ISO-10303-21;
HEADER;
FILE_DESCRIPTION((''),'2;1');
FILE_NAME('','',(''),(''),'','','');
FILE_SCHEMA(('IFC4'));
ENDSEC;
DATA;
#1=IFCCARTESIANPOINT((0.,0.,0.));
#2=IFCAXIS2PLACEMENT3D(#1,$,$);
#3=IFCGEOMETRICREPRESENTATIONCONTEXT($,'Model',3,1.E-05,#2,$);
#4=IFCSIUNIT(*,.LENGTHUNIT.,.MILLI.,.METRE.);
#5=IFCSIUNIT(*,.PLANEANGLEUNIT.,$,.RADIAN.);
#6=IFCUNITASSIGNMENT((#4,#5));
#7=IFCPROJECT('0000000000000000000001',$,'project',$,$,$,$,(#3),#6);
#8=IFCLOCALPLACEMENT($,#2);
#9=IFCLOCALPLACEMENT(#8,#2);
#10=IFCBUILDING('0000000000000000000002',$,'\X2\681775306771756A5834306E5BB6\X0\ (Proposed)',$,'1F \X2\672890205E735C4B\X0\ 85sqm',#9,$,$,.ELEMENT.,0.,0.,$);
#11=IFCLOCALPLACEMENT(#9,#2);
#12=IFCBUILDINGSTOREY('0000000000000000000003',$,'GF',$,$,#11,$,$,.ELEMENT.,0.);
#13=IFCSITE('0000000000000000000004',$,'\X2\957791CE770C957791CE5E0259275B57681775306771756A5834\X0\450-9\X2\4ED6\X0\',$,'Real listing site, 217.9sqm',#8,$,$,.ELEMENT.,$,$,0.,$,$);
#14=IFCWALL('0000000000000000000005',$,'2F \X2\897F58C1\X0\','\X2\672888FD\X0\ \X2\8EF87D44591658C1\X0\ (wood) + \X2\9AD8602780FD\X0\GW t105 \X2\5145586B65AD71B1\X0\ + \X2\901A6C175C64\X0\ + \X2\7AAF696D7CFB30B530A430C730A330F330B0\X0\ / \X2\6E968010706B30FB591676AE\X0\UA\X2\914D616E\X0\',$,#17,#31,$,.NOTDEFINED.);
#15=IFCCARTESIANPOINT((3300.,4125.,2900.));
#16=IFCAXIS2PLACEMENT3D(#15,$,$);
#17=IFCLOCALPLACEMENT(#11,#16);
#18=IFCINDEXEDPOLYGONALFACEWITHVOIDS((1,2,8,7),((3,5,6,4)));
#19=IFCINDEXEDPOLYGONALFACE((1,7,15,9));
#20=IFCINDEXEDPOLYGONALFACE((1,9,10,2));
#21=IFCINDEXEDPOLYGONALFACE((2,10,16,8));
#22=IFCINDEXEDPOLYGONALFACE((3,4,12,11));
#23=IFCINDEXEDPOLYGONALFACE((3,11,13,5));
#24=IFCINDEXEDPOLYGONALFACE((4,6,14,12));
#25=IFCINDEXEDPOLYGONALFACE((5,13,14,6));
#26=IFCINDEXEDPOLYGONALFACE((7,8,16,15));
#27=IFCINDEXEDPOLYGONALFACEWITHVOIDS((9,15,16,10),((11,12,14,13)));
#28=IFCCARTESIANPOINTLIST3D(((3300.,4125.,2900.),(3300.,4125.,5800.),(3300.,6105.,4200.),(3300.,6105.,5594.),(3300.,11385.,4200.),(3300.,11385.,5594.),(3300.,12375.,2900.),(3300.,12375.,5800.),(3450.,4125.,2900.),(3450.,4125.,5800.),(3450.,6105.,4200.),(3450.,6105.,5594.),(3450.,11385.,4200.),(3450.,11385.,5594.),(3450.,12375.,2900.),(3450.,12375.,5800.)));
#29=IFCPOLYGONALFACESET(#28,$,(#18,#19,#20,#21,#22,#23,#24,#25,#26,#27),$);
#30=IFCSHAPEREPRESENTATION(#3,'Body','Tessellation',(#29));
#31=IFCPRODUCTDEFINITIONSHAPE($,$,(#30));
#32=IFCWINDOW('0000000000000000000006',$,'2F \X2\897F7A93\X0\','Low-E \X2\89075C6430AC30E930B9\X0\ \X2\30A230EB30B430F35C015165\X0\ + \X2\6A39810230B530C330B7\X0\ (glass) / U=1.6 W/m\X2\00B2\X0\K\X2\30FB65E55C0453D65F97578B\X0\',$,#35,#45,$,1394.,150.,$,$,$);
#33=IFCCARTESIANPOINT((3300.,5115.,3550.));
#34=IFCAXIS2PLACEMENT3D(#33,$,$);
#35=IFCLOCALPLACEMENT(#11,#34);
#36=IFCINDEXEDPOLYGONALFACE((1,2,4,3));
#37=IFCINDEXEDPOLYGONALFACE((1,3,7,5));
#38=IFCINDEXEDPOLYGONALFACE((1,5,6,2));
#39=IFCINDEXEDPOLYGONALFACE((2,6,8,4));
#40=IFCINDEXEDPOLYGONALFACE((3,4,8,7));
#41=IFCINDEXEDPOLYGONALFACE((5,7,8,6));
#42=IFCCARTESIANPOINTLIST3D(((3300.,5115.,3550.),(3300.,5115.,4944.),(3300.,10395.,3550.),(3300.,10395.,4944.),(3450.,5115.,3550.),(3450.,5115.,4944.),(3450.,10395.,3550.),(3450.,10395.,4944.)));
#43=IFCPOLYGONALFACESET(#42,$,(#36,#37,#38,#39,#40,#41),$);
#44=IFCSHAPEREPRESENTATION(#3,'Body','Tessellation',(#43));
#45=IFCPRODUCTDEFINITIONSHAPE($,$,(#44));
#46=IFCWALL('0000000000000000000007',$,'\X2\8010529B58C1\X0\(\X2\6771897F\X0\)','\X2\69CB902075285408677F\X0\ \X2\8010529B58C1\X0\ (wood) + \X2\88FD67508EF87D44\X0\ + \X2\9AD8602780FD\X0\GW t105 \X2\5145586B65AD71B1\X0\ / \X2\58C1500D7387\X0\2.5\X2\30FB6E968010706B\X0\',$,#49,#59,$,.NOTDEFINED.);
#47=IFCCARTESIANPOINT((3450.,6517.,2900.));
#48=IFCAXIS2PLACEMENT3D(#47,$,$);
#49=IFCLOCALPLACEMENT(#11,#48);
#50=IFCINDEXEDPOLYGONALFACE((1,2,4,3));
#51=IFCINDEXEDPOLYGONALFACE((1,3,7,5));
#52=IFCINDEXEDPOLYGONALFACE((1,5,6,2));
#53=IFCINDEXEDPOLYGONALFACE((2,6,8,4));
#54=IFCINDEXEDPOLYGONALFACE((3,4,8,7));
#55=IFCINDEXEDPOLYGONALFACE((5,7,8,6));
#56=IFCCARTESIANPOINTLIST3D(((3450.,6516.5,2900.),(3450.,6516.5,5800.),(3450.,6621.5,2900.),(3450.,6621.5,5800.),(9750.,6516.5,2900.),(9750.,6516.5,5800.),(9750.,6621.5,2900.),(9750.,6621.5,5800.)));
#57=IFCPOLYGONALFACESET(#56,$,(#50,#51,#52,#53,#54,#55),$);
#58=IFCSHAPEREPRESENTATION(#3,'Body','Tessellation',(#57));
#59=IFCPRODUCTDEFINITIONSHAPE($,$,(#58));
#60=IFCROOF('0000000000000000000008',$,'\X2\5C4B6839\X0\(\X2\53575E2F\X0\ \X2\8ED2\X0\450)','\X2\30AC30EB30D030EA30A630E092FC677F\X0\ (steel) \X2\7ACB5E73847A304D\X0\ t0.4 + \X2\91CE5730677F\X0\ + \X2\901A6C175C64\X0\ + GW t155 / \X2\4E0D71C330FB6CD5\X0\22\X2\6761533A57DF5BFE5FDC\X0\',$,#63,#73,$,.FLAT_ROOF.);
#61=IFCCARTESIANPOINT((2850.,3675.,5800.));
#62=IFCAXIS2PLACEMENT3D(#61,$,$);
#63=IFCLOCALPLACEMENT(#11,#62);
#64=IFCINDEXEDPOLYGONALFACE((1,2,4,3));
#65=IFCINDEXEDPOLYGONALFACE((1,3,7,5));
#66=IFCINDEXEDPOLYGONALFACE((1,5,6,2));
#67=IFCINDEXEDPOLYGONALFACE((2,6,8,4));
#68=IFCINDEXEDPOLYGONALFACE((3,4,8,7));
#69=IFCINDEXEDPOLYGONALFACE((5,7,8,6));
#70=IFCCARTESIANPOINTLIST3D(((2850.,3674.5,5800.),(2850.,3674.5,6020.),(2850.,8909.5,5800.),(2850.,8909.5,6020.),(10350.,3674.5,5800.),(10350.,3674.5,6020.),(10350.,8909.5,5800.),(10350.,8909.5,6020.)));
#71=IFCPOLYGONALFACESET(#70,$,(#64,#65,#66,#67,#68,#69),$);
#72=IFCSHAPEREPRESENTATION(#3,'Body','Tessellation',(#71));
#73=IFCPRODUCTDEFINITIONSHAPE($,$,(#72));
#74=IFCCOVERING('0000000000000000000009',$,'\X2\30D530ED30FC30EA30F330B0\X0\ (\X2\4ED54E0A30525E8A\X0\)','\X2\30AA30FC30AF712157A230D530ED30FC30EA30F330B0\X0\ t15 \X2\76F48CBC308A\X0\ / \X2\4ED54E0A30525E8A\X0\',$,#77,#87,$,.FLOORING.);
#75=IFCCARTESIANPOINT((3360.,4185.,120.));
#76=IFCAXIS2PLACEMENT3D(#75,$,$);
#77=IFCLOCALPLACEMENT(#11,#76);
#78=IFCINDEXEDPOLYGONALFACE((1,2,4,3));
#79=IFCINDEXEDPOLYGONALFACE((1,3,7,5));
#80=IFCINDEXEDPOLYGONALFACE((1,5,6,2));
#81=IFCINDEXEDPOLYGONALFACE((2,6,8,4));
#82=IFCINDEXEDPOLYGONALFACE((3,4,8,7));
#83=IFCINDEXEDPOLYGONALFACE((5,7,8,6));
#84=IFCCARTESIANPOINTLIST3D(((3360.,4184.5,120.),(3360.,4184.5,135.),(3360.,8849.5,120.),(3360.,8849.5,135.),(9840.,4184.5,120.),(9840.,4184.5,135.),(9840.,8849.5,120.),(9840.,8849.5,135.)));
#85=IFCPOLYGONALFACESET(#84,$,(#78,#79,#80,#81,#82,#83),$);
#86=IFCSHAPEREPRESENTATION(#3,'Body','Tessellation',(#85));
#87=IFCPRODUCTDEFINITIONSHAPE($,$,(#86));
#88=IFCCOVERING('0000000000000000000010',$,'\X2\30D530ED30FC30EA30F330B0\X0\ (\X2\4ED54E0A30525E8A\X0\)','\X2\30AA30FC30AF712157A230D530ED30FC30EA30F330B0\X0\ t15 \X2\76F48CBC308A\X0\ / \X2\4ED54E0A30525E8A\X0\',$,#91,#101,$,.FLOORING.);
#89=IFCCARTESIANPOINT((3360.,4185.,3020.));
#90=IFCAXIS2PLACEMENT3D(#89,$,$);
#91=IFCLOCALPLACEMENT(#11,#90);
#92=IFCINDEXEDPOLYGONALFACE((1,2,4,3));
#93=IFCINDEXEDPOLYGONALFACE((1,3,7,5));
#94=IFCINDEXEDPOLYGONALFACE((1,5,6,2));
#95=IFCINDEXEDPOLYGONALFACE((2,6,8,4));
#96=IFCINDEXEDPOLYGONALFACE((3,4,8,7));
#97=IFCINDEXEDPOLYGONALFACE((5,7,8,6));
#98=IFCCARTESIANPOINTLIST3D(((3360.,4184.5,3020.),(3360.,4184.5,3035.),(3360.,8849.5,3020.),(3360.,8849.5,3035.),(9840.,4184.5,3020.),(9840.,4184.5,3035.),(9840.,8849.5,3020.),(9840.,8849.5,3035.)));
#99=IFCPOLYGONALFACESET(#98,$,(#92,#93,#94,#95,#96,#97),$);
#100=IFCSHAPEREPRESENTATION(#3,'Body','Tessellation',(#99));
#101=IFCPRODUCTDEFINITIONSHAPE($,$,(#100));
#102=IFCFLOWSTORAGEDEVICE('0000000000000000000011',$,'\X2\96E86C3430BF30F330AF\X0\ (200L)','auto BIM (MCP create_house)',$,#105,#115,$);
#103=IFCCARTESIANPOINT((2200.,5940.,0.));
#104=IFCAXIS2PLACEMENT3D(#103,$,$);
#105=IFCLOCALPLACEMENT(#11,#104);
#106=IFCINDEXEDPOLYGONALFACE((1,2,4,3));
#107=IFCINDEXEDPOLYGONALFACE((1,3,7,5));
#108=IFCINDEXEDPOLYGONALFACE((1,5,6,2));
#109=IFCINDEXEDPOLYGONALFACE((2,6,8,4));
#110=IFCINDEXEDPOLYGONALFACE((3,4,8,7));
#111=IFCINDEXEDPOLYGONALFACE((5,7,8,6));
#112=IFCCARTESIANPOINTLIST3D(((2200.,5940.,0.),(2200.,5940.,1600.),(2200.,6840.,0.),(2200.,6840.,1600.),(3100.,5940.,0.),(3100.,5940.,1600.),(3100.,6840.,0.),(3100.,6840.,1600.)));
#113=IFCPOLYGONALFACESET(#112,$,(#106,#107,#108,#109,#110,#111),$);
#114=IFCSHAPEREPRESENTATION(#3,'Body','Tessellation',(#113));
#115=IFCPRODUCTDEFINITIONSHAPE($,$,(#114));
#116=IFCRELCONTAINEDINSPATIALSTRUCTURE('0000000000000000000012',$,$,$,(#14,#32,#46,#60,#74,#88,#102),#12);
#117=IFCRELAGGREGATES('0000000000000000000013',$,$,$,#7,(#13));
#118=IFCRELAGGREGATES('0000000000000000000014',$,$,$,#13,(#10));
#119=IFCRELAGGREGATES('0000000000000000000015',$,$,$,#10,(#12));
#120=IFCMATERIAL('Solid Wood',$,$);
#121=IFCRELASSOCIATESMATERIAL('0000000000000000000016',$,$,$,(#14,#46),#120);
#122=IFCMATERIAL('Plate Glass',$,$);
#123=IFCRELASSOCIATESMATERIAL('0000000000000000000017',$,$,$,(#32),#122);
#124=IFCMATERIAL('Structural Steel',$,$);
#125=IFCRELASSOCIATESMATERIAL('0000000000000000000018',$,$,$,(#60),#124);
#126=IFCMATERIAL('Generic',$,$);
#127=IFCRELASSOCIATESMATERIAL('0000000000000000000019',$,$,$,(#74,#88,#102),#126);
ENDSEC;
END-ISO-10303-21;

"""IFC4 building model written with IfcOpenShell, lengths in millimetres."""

from ifc_helpers import new_model, si_unit, frame, frame_2d, origin, place, context, project, spatial, rectangle, extrude, material, element, fill, save


model = new_model("IFC4")

# Units and contexts
model_context = context("Model", 3, precision=1e-05, world=origin())
ifc_project = project(units=[si_unit("LENGTHUNIT", "METRE", prefix="MILLI"), si_unit("PLANEANGLEUNIT", "RADIAN")], contexts=[model_context])

# Site, building, storey
site_placement = place(None, origin())
site = spatial("IfcSite", under=ifc_project, at=site_placement, Name="長野県長野市大字栗田東番場450-9他", ObjectType="Real listing site, 217.9sqm", CompositionType="ELEMENT", RefElevation=0.0)
building_placement = place(site_placement, origin())
building = spatial("IfcBuilding", under=site, at=building_placement, Name="栗田東番場の家 (Proposed)", ObjectType="1F 木造平屋 85sqm", CompositionType="ELEMENT", ElevationOfRefHeight=0.0, ElevationOfTerrain=0.0)
storey_placement = place(building_placement, origin())
storey = spatial("IfcBuildingStorey", under=building, at=storey_placement, Name="GF", CompositionType="ELEMENT", Elevation=0.0)

# Shared definitions
ifc_material_1 = material(Name="Solid Wood")
ifc_material_2 = material(Name="Generic")

# Shared definitions
ifc_material_3 = material(Name="Plate Glass")

# Wall, opening, window
wall_1_placement = place(storey_placement, frame((3300.0, 4125.0, 2900.0)))
wall_1 = element("IfcWall", 1, at=wall_1_placement, inside=storey, material=ifc_material_1, Name="2F 西壁", Description="木製 軸組外壁 (wood) + 高性能GW t105 充填断熱 + 通気層 + 窯業系サイディング / 準耐火・外皮UA配慮", PredefinedType="NOTDEFINED", context=model_context, shape_type="SweptSolid", body=[
    extrude(rectangle(XDim=150.0, YDim=8250.0, at=frame_2d((75.0, 4125.0))), frame((3300.0, 4125.0, 2900.0)), (0.0, 0.0, 1.0), 2900.0),
])
opening_1_placement = place(storey_placement, frame((3300.0, 5115.0, 3550.0)))
opening_1 = element("IfcOpeningElement", 2, at=opening_1_placement, cuts=wall_1, PredefinedType="NOTDEFINED", context=model_context, shape_type="SweptSolid", body=[
    extrude(rectangle(XDim=150.0, YDim=5280.0, at=frame_2d((75.0, 2640.0))), frame((3300.0, 5115.0, 3550.0)), (0.0, 0.0, 1.0), 1394.0),
])
window_1_placement = place(storey_placement, frame((3300.0, 5115.0, 3550.0)))
window_1 = element("IfcWindow", 3, at=window_1_placement, inside=storey, material=ifc_material_3, Name="2F 西窓", Description="Low-E 複層ガラス アルゴン封入 + 樹脂サッシ (glass) / U=1.6 W/m²K・日射取得型", OverallHeight=1394.0, OverallWidth=150.0, context=model_context, shape_type="SweptSolid", body=[
    extrude(rectangle(XDim=150.0, YDim=5280.0, at=frame_2d((75.0, 2640.0))), frame((3300.0, 5115.0, 3550.0)), (0.0, 0.0, 1.0), 1394.0),
])
fill(opening_1, window_1)

# Wall
wall_2_placement = place(storey_placement, frame((3450.0, 6517.0, 2900.0)))
element("IfcWall", 4, at=wall_2_placement, inside=storey, material=ifc_material_1, Name="耐力壁(東西)", Description="構造用合板 耐力壁 (wood) + 製材軸組 + 高性能GW t105 充填断熱 / 壁倍率2.5・準耐火", PredefinedType="NOTDEFINED", context=model_context, shape_type="SweptSolid", body=[
    extrude(rectangle(XDim=6300.0, YDim=105.0, at=frame_2d((3150.0, 52.0))), frame((3450.0, 6517.0, 2900.0)), (0.0, 0.0, 1.0), 2900.0),
])

# Roof
ifc_material_4 = material(Name="Structural Steel")
for number, where, name in (
    (5, (2850.0, 3675.0, 5800.0), "屋根(南帯 軒450)"),
):
    element("IfcRoof", number, at=place(storey_placement, frame(where)), inside=storey, material=ifc_material_4, Name=name, Description="ガルバリウム鋼板 (steel) 立平葺き t0.4 + 野地板 + 通気層 + GW t155 / 不燃・法22条区域対応", PredefinedType="FLAT_ROOF", context=model_context, shape_type="SweptSolid", body=[
        extrude(rectangle(XDim=7500.0, YDim=5235.0, at=frame_2d((3750.0, 2617.0))), frame((2850.0, 3675.0, 5800.0)), (0.0, 0.0, 1.0), 220.0),
    ])

# Coverings
covering_1_placement = place(storey_placement, frame((3360.0, 4185.0, 120.0)))
element("IfcCovering", 6, at=covering_1_placement, inside=storey, material=ifc_material_2, Name="フローリング (仕上げ床)", Description="オーク無垢フローリング t15 直貼り / 仕上げ床", PredefinedType="FLOORING", context=model_context, shape_type="SweptSolid", body=[
    extrude(rectangle(XDim=6480.0, YDim=4665.0, at=frame_2d((3240.0, 2332.0))), frame((3360.0, 4185.0, 120.0)), (0.0, 0.0, 1.0), 15.0),
])
covering_2_placement = place(storey_placement, frame((3360.0, 4185.0, 3020.0)))
element("IfcCovering", 7, at=covering_2_placement, inside=storey, material=ifc_material_2, Name="フローリング (仕上げ床)", Description="オーク無垢フローリング t15 直貼り / 仕上げ床", PredefinedType="FLOORING", context=model_context, shape_type="SweptSolid", body=[
    extrude(rectangle(XDim=6480.0, YDim=4665.0, at=frame_2d((3240.0, 2332.0))), frame((3360.0, 4185.0, 3020.0)), (0.0, 0.0, 1.0), 15.0),
])

# Flow storage device
flow_storage_device_placement = place(storey_placement, frame((2200.0, 5940.0, 0.0)))
element("IfcFlowStorageDevice", 8, at=flow_storage_device_placement, inside=storey, material=ifc_material_2, Name="雨水タンク (200L)", Description="auto BIM (MCP create_house)", context=model_context, shape_type="SweptSolid", body=[
    extrude(rectangle(XDim=900.0, YDim=900.0, at=frame_2d((450.0, 450.0))), frame((2200.0, 5940.0, 0.0)), (0.0, 0.0, 1.0), 1600.0),
])

save(model, "model.ifc")
